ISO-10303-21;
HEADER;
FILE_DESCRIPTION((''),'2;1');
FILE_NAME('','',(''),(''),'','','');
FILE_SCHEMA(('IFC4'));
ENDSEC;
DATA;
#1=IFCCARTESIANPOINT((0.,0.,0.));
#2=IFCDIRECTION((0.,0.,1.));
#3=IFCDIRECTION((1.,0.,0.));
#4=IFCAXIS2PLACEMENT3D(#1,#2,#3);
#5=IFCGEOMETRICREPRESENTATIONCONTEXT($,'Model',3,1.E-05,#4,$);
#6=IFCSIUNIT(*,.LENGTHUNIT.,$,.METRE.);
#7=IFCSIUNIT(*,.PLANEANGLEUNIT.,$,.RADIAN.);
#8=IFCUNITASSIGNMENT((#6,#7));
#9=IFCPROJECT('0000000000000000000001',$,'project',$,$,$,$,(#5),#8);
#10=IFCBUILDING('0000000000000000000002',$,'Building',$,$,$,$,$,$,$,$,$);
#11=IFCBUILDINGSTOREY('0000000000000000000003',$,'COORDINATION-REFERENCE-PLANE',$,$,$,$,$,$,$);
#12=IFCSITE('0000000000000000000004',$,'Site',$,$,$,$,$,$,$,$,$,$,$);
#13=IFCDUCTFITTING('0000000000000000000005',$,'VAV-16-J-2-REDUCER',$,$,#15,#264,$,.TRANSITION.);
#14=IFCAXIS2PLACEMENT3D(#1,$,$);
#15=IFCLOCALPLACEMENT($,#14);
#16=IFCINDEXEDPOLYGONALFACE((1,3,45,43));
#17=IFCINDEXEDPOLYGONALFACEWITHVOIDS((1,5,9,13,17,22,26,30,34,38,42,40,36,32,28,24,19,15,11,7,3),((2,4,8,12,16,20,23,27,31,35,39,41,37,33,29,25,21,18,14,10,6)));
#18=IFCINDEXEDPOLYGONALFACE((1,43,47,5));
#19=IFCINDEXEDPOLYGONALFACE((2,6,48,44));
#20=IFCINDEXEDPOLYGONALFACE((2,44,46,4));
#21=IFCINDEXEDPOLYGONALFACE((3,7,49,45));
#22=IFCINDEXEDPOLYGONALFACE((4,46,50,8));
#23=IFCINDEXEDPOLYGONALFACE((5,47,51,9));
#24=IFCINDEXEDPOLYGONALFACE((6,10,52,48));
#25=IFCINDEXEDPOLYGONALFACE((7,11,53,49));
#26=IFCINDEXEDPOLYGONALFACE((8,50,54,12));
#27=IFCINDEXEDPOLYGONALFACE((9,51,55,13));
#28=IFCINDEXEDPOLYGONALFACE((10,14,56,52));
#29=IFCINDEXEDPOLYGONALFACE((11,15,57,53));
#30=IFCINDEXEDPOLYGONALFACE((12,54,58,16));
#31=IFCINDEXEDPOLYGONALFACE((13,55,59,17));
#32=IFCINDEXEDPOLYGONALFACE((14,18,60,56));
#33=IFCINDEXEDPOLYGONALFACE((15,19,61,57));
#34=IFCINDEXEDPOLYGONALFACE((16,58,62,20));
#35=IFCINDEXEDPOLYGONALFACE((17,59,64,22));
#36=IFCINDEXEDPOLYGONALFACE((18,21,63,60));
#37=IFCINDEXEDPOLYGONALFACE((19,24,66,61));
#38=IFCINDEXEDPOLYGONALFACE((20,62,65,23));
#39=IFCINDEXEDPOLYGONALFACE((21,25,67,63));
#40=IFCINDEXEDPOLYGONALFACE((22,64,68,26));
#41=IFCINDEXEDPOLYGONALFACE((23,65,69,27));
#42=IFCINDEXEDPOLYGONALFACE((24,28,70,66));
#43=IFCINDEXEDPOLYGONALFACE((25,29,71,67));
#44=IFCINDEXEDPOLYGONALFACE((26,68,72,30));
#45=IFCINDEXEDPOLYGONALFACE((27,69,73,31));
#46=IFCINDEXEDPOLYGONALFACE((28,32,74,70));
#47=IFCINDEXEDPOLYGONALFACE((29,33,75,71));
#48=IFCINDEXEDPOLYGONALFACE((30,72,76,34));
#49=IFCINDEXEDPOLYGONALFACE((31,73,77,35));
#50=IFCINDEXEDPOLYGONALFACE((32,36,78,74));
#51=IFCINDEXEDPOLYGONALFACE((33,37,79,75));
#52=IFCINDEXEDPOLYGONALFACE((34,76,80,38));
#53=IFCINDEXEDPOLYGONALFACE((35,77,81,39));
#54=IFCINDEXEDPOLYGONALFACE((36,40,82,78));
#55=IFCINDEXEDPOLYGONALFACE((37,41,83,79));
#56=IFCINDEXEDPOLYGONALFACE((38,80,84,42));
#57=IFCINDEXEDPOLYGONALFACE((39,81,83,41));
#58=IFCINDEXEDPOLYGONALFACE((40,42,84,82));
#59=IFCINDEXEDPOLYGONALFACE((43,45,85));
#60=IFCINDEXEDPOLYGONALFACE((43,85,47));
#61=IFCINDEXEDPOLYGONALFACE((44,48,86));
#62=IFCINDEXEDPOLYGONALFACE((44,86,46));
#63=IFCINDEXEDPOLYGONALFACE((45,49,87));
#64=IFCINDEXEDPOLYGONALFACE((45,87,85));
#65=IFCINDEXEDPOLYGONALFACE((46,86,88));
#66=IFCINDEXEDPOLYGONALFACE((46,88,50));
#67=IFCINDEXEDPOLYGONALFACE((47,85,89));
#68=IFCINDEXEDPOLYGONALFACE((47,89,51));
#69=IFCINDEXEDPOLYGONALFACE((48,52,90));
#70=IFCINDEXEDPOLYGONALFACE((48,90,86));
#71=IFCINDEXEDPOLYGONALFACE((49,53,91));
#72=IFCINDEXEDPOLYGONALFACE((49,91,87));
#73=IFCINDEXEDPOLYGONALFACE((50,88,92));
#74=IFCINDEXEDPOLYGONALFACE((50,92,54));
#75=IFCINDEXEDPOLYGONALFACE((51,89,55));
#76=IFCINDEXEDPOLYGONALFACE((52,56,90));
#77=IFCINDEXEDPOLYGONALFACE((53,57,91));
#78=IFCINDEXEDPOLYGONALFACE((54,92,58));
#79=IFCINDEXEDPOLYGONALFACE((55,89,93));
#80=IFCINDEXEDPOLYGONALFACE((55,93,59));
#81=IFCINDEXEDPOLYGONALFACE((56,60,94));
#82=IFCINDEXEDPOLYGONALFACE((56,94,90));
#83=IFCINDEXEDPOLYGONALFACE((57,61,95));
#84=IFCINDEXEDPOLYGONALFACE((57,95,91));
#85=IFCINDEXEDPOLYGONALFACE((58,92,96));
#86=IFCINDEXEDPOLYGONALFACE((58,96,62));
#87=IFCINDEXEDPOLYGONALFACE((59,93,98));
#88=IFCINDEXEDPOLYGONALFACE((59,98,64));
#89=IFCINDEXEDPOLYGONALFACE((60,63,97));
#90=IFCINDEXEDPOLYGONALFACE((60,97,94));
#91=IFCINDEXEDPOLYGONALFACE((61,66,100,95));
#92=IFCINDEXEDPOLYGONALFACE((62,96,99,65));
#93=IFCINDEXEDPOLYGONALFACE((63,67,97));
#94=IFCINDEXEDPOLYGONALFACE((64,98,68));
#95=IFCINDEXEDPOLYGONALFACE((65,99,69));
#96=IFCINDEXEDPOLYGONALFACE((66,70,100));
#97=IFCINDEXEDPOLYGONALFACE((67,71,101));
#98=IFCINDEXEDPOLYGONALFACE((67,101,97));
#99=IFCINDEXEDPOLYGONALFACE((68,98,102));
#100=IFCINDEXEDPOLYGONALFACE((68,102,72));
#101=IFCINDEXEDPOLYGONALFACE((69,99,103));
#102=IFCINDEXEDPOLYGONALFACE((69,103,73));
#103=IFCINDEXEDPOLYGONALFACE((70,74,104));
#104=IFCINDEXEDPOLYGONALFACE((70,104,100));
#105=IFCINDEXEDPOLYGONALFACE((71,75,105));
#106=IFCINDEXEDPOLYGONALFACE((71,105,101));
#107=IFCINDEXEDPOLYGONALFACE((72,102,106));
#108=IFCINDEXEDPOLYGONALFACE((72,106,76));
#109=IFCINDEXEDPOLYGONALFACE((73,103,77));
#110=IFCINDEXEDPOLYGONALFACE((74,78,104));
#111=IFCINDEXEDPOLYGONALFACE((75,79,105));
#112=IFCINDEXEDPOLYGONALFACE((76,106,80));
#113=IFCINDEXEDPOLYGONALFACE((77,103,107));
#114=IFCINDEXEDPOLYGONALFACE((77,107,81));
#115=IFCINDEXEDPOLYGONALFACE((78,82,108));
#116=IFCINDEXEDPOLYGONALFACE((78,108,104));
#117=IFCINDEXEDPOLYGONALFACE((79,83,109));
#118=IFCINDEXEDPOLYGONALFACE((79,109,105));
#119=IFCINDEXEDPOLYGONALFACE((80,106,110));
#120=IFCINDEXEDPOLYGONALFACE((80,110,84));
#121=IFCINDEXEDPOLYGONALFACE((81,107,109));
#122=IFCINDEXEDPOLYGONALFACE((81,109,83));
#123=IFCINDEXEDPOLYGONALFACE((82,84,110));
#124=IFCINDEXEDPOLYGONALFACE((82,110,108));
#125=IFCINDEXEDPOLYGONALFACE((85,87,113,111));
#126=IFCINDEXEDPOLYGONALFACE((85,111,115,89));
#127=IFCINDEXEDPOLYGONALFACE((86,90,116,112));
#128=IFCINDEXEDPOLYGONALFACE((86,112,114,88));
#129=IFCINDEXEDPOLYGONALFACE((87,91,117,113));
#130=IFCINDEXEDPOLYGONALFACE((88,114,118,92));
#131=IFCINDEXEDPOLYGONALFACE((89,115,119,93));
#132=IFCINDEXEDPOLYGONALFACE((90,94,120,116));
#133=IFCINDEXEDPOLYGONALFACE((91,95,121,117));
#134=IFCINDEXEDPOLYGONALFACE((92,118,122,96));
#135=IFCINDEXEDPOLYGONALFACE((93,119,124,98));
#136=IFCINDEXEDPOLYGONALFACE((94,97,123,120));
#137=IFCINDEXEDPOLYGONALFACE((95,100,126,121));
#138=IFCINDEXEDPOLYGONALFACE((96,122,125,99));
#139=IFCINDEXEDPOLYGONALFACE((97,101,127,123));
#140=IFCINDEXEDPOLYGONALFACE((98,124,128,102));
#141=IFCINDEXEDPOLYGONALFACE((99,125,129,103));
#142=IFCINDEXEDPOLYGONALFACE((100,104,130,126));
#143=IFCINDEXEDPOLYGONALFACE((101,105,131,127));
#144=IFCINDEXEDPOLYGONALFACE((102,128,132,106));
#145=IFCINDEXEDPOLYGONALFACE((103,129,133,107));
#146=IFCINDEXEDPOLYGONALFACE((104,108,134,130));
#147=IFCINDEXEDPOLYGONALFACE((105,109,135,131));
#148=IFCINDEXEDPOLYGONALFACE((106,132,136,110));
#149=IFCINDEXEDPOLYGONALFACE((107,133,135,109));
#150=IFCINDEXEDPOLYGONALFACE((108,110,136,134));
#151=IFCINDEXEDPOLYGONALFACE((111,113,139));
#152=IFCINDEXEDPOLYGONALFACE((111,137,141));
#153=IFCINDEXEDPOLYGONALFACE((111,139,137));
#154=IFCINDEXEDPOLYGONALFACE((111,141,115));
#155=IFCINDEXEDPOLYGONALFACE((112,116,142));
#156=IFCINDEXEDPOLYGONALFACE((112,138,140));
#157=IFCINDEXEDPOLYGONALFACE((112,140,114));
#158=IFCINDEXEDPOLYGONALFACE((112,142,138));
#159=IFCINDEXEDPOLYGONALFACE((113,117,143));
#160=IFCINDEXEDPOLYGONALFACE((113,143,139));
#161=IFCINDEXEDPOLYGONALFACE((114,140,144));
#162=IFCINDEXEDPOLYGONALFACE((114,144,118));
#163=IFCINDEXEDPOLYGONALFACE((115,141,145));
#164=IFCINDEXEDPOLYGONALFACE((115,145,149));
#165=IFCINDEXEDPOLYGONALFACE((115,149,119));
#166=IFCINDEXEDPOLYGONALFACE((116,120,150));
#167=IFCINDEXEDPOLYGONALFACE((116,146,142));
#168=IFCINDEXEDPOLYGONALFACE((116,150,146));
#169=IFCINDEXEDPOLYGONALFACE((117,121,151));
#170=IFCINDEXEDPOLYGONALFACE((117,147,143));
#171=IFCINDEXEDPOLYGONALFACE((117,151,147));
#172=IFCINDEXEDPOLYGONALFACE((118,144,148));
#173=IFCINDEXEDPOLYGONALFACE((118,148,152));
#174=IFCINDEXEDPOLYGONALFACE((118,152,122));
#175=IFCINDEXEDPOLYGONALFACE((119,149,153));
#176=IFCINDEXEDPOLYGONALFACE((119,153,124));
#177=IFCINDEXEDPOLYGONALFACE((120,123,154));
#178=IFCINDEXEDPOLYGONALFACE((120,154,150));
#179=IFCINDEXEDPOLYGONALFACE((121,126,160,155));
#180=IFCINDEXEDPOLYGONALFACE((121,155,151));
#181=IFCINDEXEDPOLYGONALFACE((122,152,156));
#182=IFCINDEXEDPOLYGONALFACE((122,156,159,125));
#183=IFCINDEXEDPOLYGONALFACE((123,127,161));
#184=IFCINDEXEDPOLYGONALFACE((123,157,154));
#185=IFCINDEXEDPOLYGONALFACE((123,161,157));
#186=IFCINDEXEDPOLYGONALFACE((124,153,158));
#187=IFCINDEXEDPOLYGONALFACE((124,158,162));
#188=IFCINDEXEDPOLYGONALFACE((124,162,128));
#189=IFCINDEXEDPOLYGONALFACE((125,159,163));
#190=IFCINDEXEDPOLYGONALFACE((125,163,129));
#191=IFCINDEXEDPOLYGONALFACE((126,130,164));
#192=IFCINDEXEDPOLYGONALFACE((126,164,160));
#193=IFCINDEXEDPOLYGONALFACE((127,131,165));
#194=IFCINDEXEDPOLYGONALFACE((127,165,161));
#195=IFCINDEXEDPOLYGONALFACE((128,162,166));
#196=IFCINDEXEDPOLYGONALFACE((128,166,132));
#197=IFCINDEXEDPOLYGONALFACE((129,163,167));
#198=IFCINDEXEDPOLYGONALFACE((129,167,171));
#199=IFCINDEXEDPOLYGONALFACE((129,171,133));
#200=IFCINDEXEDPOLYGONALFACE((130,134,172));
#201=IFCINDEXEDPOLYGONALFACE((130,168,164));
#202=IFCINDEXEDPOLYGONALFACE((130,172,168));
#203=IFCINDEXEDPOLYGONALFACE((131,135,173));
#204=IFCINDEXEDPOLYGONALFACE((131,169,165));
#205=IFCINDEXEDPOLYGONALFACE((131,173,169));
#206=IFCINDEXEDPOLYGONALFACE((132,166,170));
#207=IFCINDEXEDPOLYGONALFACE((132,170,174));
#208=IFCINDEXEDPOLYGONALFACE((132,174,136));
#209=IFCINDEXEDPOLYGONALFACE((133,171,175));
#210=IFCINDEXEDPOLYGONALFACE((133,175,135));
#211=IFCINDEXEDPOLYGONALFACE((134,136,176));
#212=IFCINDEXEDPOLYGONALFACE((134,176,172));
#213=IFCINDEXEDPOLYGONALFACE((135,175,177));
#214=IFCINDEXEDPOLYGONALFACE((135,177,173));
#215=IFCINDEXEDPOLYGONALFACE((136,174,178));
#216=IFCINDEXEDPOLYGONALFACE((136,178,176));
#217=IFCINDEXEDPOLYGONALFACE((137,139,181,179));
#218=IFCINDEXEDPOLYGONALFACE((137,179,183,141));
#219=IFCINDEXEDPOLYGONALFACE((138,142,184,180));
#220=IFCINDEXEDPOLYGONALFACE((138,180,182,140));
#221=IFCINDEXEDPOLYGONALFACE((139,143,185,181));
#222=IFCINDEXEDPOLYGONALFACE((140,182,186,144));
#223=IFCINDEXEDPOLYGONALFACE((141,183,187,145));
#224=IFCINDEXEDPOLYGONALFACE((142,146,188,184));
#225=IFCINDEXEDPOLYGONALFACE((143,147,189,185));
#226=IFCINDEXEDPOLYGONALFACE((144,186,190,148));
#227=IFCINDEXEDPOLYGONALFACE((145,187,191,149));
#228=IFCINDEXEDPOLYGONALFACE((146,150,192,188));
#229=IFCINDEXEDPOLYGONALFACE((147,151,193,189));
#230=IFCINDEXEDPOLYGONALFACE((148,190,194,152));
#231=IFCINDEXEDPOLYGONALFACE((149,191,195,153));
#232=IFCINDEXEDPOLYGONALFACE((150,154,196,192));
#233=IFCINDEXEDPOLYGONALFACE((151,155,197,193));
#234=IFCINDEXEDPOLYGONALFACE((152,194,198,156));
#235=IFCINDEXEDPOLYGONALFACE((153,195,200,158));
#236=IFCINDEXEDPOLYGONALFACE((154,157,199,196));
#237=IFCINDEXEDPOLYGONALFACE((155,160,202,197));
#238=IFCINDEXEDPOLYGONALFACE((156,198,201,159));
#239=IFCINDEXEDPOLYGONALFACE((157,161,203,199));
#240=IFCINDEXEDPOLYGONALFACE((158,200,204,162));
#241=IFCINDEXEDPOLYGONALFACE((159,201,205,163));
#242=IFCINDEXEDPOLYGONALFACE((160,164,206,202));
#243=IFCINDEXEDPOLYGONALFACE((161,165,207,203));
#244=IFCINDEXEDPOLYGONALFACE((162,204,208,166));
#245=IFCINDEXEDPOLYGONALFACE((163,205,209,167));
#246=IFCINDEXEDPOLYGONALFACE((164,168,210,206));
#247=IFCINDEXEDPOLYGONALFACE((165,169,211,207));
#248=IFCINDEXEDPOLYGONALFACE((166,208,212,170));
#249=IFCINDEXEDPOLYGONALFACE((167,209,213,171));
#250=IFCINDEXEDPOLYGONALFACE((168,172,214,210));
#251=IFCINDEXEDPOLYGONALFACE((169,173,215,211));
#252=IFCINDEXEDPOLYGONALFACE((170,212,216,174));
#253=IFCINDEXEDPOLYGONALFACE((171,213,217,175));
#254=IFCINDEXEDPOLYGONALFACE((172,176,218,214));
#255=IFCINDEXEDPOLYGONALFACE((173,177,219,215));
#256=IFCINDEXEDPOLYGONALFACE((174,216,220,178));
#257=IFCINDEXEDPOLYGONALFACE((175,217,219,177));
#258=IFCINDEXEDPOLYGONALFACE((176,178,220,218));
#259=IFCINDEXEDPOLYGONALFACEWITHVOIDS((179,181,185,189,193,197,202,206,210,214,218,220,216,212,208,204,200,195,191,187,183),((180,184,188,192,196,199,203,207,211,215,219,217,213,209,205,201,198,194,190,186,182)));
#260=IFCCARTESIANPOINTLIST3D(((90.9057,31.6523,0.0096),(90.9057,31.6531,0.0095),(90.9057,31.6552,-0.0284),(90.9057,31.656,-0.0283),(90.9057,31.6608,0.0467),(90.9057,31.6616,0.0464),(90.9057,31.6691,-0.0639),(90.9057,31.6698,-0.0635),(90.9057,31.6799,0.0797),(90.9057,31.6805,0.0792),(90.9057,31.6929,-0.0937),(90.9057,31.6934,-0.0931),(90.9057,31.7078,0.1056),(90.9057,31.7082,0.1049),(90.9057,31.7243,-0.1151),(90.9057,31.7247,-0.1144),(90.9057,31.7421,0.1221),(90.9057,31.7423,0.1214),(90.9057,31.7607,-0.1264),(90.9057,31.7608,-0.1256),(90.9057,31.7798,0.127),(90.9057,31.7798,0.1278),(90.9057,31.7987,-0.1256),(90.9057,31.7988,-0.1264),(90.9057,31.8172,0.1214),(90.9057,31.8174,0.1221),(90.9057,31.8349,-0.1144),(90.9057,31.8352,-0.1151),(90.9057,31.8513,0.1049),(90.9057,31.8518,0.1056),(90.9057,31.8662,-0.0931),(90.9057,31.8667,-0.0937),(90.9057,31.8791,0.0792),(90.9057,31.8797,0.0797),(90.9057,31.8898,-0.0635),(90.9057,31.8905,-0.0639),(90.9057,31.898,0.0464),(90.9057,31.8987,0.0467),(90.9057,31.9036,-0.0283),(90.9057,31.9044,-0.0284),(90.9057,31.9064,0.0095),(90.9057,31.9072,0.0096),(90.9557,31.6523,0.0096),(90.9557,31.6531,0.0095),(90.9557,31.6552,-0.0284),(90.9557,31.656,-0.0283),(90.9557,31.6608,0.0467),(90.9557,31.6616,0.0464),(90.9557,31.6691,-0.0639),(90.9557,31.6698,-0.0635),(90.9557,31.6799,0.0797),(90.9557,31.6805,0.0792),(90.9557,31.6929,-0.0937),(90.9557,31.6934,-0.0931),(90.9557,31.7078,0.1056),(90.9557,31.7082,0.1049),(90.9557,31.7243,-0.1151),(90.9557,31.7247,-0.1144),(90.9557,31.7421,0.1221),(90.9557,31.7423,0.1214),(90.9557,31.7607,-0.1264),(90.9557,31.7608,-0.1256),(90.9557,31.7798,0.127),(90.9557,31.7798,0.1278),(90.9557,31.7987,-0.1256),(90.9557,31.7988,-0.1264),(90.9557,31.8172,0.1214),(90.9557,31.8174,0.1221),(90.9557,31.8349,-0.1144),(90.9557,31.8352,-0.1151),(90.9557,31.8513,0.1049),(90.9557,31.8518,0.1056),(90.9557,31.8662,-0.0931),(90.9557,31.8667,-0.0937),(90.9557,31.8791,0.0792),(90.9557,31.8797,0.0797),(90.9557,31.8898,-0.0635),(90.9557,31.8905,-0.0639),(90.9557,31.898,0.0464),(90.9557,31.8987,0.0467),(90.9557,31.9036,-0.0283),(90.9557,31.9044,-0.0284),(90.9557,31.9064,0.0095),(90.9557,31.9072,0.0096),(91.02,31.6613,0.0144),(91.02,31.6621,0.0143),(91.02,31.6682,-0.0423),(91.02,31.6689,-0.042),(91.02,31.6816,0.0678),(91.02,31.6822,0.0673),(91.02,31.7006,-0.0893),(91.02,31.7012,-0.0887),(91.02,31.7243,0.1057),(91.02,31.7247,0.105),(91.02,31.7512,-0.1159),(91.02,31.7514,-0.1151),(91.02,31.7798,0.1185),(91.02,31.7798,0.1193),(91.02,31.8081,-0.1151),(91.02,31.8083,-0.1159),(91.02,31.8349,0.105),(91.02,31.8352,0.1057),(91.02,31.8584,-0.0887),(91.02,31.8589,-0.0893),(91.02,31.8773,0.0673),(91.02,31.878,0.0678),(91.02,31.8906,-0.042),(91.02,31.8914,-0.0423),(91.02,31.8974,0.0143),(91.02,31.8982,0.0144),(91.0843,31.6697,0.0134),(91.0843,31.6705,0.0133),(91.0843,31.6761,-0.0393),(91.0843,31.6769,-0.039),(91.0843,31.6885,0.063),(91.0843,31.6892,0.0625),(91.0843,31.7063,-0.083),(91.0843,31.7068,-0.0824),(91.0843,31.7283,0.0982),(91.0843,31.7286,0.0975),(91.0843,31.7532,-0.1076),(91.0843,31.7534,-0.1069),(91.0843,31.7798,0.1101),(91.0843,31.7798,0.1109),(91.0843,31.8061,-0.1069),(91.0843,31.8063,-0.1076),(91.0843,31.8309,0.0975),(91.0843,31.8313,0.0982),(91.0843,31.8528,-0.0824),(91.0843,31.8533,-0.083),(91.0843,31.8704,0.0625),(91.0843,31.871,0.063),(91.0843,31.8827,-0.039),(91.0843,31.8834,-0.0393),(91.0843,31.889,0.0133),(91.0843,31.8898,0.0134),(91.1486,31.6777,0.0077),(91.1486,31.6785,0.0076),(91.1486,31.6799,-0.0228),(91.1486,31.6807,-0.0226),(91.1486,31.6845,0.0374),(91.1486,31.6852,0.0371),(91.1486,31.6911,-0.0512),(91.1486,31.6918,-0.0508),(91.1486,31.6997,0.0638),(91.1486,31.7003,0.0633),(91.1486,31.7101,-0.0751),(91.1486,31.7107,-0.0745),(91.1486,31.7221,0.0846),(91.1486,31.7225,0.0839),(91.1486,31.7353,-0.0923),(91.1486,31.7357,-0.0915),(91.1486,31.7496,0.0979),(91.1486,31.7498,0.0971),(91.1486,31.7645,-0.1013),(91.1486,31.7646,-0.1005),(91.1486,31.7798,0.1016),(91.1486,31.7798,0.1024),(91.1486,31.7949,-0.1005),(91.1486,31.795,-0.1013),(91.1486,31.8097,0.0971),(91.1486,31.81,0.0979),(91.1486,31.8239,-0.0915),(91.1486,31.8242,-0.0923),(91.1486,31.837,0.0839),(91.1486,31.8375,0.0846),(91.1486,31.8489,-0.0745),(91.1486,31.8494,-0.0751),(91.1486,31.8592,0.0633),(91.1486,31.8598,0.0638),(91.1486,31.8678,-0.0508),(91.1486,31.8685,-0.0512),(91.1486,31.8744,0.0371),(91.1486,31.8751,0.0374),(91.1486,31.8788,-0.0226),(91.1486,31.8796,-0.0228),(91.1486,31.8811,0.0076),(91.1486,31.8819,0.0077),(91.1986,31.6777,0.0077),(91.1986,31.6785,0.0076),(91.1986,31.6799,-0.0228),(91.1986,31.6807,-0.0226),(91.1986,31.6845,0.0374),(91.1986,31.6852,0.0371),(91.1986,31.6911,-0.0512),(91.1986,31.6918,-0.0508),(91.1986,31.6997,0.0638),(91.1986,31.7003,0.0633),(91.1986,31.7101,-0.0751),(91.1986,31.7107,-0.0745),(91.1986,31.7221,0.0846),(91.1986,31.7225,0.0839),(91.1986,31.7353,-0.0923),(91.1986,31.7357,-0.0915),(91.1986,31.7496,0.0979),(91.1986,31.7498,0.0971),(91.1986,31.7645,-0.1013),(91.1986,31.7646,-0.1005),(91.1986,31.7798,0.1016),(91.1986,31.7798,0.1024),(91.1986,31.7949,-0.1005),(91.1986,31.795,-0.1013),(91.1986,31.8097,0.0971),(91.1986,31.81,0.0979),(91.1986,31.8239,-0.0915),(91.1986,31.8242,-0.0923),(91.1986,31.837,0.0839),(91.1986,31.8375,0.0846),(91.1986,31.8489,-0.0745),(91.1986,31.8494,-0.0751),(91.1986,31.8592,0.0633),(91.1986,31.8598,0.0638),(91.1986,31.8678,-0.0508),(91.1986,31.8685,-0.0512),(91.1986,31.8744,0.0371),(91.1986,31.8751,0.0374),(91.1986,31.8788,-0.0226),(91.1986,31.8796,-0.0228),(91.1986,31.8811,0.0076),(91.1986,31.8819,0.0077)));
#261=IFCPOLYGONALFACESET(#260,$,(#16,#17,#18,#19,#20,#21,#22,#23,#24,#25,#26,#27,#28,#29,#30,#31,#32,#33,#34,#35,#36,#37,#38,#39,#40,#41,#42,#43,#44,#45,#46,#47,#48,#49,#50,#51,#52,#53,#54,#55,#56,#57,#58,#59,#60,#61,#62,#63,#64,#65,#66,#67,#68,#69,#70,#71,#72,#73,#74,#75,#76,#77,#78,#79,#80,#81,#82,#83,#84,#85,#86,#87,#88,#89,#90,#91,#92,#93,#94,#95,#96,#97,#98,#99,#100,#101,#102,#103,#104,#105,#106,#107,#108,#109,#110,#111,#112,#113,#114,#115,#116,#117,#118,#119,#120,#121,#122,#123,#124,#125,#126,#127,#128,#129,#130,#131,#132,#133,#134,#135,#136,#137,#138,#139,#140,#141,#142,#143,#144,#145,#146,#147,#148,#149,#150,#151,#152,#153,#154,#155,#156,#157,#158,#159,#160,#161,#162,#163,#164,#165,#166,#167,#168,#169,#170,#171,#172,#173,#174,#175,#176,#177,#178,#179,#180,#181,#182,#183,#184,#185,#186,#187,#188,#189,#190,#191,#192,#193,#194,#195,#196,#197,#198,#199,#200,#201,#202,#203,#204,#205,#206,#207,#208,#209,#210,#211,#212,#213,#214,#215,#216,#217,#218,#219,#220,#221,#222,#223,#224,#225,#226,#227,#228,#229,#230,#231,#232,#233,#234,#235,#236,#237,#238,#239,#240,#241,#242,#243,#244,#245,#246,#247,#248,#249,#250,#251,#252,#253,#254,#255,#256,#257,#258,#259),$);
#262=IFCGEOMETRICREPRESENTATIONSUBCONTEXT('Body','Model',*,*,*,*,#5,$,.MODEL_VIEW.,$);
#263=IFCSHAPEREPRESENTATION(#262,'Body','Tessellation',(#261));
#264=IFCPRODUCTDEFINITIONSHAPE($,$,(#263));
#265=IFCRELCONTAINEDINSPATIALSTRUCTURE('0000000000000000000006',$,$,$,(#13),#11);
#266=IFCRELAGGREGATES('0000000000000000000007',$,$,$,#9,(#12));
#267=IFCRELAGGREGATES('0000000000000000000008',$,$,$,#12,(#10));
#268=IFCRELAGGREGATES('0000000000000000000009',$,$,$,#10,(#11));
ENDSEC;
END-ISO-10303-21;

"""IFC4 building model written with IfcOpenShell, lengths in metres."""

from ifc_helpers import new_model, entity, si_unit, frame, origin_with_axes, place, context, subcontext, project, spatial, element, save


model = new_model("IFC4")

# Units and contexts
model_context = context("Model", 3, precision=1e-05, world=origin_with_axes())
body_context_1 = subcontext(model_context, "Body", "Model", "MODEL_VIEW")
ifc_project = project(units=[si_unit("LENGTHUNIT", "METRE"), si_unit("PLANEANGLEUNIT", "RADIAN")], contexts=[model_context])

# Site, building, storey
site = spatial("IfcSite", under=ifc_project, Name="Site")
building = spatial("IfcBuilding", under=site, Name="Building")
storey = spatial("IfcBuildingStorey", under=building, Name="COORDINATION-REFERENCE-PLANE")

# Duct fitting
for number, where, z_axis, x_axis, name in (
    (1, (90.9057, 31.7798, 0.0), (0.0, 1.0, 0.0), (0.0, 0.0, 1.0), "VAV-16-J-2-REDUCER"),
):
    element("IfcDuctFitting", number, at=place(None, frame(where, z_axis=z_axis, x_axis=x_axis)), inside=storey, Name=name, PredefinedType="TRANSITION", context=body_context_1, shape_type="SweptSolid", body=[
        entity("IfcRevolvedAreaSolid", entity("IfcArbitraryClosedProfileDef", "AREA", None, entity("IfcPolyline", [entity("IfcCartesianPoint", [0.1278, 0.0]), entity("IfcCartesianPoint", [0.1278, 0.05]), entity("IfcCartesianPoint", [0.1024, 0.2429]), entity("IfcCartesianPoint", [0.1024, 0.2929]), entity("IfcCartesianPoint", [0.1016, 0.2929]), entity("IfcCartesianPoint", [0.1016, 0.2429]), entity("IfcCartesianPoint", [0.127, 0.05]), entity("IfcCartesianPoint", [0.127, 0.0]), entity("IfcCartesianPoint", [0.1278, 0.0])])), entity("IfcAxis2Placement3D", entity("IfcCartesianPoint", [0.0, 0.0, 0.0])), entity("IfcAxis1Placement", entity("IfcCartesianPoint", [0.0, 0.0, 0.0]), entity("IfcDirection", [0.0, 1.0, 0.0])), 6.283185),
    ])

save(model, "model.ifc")
